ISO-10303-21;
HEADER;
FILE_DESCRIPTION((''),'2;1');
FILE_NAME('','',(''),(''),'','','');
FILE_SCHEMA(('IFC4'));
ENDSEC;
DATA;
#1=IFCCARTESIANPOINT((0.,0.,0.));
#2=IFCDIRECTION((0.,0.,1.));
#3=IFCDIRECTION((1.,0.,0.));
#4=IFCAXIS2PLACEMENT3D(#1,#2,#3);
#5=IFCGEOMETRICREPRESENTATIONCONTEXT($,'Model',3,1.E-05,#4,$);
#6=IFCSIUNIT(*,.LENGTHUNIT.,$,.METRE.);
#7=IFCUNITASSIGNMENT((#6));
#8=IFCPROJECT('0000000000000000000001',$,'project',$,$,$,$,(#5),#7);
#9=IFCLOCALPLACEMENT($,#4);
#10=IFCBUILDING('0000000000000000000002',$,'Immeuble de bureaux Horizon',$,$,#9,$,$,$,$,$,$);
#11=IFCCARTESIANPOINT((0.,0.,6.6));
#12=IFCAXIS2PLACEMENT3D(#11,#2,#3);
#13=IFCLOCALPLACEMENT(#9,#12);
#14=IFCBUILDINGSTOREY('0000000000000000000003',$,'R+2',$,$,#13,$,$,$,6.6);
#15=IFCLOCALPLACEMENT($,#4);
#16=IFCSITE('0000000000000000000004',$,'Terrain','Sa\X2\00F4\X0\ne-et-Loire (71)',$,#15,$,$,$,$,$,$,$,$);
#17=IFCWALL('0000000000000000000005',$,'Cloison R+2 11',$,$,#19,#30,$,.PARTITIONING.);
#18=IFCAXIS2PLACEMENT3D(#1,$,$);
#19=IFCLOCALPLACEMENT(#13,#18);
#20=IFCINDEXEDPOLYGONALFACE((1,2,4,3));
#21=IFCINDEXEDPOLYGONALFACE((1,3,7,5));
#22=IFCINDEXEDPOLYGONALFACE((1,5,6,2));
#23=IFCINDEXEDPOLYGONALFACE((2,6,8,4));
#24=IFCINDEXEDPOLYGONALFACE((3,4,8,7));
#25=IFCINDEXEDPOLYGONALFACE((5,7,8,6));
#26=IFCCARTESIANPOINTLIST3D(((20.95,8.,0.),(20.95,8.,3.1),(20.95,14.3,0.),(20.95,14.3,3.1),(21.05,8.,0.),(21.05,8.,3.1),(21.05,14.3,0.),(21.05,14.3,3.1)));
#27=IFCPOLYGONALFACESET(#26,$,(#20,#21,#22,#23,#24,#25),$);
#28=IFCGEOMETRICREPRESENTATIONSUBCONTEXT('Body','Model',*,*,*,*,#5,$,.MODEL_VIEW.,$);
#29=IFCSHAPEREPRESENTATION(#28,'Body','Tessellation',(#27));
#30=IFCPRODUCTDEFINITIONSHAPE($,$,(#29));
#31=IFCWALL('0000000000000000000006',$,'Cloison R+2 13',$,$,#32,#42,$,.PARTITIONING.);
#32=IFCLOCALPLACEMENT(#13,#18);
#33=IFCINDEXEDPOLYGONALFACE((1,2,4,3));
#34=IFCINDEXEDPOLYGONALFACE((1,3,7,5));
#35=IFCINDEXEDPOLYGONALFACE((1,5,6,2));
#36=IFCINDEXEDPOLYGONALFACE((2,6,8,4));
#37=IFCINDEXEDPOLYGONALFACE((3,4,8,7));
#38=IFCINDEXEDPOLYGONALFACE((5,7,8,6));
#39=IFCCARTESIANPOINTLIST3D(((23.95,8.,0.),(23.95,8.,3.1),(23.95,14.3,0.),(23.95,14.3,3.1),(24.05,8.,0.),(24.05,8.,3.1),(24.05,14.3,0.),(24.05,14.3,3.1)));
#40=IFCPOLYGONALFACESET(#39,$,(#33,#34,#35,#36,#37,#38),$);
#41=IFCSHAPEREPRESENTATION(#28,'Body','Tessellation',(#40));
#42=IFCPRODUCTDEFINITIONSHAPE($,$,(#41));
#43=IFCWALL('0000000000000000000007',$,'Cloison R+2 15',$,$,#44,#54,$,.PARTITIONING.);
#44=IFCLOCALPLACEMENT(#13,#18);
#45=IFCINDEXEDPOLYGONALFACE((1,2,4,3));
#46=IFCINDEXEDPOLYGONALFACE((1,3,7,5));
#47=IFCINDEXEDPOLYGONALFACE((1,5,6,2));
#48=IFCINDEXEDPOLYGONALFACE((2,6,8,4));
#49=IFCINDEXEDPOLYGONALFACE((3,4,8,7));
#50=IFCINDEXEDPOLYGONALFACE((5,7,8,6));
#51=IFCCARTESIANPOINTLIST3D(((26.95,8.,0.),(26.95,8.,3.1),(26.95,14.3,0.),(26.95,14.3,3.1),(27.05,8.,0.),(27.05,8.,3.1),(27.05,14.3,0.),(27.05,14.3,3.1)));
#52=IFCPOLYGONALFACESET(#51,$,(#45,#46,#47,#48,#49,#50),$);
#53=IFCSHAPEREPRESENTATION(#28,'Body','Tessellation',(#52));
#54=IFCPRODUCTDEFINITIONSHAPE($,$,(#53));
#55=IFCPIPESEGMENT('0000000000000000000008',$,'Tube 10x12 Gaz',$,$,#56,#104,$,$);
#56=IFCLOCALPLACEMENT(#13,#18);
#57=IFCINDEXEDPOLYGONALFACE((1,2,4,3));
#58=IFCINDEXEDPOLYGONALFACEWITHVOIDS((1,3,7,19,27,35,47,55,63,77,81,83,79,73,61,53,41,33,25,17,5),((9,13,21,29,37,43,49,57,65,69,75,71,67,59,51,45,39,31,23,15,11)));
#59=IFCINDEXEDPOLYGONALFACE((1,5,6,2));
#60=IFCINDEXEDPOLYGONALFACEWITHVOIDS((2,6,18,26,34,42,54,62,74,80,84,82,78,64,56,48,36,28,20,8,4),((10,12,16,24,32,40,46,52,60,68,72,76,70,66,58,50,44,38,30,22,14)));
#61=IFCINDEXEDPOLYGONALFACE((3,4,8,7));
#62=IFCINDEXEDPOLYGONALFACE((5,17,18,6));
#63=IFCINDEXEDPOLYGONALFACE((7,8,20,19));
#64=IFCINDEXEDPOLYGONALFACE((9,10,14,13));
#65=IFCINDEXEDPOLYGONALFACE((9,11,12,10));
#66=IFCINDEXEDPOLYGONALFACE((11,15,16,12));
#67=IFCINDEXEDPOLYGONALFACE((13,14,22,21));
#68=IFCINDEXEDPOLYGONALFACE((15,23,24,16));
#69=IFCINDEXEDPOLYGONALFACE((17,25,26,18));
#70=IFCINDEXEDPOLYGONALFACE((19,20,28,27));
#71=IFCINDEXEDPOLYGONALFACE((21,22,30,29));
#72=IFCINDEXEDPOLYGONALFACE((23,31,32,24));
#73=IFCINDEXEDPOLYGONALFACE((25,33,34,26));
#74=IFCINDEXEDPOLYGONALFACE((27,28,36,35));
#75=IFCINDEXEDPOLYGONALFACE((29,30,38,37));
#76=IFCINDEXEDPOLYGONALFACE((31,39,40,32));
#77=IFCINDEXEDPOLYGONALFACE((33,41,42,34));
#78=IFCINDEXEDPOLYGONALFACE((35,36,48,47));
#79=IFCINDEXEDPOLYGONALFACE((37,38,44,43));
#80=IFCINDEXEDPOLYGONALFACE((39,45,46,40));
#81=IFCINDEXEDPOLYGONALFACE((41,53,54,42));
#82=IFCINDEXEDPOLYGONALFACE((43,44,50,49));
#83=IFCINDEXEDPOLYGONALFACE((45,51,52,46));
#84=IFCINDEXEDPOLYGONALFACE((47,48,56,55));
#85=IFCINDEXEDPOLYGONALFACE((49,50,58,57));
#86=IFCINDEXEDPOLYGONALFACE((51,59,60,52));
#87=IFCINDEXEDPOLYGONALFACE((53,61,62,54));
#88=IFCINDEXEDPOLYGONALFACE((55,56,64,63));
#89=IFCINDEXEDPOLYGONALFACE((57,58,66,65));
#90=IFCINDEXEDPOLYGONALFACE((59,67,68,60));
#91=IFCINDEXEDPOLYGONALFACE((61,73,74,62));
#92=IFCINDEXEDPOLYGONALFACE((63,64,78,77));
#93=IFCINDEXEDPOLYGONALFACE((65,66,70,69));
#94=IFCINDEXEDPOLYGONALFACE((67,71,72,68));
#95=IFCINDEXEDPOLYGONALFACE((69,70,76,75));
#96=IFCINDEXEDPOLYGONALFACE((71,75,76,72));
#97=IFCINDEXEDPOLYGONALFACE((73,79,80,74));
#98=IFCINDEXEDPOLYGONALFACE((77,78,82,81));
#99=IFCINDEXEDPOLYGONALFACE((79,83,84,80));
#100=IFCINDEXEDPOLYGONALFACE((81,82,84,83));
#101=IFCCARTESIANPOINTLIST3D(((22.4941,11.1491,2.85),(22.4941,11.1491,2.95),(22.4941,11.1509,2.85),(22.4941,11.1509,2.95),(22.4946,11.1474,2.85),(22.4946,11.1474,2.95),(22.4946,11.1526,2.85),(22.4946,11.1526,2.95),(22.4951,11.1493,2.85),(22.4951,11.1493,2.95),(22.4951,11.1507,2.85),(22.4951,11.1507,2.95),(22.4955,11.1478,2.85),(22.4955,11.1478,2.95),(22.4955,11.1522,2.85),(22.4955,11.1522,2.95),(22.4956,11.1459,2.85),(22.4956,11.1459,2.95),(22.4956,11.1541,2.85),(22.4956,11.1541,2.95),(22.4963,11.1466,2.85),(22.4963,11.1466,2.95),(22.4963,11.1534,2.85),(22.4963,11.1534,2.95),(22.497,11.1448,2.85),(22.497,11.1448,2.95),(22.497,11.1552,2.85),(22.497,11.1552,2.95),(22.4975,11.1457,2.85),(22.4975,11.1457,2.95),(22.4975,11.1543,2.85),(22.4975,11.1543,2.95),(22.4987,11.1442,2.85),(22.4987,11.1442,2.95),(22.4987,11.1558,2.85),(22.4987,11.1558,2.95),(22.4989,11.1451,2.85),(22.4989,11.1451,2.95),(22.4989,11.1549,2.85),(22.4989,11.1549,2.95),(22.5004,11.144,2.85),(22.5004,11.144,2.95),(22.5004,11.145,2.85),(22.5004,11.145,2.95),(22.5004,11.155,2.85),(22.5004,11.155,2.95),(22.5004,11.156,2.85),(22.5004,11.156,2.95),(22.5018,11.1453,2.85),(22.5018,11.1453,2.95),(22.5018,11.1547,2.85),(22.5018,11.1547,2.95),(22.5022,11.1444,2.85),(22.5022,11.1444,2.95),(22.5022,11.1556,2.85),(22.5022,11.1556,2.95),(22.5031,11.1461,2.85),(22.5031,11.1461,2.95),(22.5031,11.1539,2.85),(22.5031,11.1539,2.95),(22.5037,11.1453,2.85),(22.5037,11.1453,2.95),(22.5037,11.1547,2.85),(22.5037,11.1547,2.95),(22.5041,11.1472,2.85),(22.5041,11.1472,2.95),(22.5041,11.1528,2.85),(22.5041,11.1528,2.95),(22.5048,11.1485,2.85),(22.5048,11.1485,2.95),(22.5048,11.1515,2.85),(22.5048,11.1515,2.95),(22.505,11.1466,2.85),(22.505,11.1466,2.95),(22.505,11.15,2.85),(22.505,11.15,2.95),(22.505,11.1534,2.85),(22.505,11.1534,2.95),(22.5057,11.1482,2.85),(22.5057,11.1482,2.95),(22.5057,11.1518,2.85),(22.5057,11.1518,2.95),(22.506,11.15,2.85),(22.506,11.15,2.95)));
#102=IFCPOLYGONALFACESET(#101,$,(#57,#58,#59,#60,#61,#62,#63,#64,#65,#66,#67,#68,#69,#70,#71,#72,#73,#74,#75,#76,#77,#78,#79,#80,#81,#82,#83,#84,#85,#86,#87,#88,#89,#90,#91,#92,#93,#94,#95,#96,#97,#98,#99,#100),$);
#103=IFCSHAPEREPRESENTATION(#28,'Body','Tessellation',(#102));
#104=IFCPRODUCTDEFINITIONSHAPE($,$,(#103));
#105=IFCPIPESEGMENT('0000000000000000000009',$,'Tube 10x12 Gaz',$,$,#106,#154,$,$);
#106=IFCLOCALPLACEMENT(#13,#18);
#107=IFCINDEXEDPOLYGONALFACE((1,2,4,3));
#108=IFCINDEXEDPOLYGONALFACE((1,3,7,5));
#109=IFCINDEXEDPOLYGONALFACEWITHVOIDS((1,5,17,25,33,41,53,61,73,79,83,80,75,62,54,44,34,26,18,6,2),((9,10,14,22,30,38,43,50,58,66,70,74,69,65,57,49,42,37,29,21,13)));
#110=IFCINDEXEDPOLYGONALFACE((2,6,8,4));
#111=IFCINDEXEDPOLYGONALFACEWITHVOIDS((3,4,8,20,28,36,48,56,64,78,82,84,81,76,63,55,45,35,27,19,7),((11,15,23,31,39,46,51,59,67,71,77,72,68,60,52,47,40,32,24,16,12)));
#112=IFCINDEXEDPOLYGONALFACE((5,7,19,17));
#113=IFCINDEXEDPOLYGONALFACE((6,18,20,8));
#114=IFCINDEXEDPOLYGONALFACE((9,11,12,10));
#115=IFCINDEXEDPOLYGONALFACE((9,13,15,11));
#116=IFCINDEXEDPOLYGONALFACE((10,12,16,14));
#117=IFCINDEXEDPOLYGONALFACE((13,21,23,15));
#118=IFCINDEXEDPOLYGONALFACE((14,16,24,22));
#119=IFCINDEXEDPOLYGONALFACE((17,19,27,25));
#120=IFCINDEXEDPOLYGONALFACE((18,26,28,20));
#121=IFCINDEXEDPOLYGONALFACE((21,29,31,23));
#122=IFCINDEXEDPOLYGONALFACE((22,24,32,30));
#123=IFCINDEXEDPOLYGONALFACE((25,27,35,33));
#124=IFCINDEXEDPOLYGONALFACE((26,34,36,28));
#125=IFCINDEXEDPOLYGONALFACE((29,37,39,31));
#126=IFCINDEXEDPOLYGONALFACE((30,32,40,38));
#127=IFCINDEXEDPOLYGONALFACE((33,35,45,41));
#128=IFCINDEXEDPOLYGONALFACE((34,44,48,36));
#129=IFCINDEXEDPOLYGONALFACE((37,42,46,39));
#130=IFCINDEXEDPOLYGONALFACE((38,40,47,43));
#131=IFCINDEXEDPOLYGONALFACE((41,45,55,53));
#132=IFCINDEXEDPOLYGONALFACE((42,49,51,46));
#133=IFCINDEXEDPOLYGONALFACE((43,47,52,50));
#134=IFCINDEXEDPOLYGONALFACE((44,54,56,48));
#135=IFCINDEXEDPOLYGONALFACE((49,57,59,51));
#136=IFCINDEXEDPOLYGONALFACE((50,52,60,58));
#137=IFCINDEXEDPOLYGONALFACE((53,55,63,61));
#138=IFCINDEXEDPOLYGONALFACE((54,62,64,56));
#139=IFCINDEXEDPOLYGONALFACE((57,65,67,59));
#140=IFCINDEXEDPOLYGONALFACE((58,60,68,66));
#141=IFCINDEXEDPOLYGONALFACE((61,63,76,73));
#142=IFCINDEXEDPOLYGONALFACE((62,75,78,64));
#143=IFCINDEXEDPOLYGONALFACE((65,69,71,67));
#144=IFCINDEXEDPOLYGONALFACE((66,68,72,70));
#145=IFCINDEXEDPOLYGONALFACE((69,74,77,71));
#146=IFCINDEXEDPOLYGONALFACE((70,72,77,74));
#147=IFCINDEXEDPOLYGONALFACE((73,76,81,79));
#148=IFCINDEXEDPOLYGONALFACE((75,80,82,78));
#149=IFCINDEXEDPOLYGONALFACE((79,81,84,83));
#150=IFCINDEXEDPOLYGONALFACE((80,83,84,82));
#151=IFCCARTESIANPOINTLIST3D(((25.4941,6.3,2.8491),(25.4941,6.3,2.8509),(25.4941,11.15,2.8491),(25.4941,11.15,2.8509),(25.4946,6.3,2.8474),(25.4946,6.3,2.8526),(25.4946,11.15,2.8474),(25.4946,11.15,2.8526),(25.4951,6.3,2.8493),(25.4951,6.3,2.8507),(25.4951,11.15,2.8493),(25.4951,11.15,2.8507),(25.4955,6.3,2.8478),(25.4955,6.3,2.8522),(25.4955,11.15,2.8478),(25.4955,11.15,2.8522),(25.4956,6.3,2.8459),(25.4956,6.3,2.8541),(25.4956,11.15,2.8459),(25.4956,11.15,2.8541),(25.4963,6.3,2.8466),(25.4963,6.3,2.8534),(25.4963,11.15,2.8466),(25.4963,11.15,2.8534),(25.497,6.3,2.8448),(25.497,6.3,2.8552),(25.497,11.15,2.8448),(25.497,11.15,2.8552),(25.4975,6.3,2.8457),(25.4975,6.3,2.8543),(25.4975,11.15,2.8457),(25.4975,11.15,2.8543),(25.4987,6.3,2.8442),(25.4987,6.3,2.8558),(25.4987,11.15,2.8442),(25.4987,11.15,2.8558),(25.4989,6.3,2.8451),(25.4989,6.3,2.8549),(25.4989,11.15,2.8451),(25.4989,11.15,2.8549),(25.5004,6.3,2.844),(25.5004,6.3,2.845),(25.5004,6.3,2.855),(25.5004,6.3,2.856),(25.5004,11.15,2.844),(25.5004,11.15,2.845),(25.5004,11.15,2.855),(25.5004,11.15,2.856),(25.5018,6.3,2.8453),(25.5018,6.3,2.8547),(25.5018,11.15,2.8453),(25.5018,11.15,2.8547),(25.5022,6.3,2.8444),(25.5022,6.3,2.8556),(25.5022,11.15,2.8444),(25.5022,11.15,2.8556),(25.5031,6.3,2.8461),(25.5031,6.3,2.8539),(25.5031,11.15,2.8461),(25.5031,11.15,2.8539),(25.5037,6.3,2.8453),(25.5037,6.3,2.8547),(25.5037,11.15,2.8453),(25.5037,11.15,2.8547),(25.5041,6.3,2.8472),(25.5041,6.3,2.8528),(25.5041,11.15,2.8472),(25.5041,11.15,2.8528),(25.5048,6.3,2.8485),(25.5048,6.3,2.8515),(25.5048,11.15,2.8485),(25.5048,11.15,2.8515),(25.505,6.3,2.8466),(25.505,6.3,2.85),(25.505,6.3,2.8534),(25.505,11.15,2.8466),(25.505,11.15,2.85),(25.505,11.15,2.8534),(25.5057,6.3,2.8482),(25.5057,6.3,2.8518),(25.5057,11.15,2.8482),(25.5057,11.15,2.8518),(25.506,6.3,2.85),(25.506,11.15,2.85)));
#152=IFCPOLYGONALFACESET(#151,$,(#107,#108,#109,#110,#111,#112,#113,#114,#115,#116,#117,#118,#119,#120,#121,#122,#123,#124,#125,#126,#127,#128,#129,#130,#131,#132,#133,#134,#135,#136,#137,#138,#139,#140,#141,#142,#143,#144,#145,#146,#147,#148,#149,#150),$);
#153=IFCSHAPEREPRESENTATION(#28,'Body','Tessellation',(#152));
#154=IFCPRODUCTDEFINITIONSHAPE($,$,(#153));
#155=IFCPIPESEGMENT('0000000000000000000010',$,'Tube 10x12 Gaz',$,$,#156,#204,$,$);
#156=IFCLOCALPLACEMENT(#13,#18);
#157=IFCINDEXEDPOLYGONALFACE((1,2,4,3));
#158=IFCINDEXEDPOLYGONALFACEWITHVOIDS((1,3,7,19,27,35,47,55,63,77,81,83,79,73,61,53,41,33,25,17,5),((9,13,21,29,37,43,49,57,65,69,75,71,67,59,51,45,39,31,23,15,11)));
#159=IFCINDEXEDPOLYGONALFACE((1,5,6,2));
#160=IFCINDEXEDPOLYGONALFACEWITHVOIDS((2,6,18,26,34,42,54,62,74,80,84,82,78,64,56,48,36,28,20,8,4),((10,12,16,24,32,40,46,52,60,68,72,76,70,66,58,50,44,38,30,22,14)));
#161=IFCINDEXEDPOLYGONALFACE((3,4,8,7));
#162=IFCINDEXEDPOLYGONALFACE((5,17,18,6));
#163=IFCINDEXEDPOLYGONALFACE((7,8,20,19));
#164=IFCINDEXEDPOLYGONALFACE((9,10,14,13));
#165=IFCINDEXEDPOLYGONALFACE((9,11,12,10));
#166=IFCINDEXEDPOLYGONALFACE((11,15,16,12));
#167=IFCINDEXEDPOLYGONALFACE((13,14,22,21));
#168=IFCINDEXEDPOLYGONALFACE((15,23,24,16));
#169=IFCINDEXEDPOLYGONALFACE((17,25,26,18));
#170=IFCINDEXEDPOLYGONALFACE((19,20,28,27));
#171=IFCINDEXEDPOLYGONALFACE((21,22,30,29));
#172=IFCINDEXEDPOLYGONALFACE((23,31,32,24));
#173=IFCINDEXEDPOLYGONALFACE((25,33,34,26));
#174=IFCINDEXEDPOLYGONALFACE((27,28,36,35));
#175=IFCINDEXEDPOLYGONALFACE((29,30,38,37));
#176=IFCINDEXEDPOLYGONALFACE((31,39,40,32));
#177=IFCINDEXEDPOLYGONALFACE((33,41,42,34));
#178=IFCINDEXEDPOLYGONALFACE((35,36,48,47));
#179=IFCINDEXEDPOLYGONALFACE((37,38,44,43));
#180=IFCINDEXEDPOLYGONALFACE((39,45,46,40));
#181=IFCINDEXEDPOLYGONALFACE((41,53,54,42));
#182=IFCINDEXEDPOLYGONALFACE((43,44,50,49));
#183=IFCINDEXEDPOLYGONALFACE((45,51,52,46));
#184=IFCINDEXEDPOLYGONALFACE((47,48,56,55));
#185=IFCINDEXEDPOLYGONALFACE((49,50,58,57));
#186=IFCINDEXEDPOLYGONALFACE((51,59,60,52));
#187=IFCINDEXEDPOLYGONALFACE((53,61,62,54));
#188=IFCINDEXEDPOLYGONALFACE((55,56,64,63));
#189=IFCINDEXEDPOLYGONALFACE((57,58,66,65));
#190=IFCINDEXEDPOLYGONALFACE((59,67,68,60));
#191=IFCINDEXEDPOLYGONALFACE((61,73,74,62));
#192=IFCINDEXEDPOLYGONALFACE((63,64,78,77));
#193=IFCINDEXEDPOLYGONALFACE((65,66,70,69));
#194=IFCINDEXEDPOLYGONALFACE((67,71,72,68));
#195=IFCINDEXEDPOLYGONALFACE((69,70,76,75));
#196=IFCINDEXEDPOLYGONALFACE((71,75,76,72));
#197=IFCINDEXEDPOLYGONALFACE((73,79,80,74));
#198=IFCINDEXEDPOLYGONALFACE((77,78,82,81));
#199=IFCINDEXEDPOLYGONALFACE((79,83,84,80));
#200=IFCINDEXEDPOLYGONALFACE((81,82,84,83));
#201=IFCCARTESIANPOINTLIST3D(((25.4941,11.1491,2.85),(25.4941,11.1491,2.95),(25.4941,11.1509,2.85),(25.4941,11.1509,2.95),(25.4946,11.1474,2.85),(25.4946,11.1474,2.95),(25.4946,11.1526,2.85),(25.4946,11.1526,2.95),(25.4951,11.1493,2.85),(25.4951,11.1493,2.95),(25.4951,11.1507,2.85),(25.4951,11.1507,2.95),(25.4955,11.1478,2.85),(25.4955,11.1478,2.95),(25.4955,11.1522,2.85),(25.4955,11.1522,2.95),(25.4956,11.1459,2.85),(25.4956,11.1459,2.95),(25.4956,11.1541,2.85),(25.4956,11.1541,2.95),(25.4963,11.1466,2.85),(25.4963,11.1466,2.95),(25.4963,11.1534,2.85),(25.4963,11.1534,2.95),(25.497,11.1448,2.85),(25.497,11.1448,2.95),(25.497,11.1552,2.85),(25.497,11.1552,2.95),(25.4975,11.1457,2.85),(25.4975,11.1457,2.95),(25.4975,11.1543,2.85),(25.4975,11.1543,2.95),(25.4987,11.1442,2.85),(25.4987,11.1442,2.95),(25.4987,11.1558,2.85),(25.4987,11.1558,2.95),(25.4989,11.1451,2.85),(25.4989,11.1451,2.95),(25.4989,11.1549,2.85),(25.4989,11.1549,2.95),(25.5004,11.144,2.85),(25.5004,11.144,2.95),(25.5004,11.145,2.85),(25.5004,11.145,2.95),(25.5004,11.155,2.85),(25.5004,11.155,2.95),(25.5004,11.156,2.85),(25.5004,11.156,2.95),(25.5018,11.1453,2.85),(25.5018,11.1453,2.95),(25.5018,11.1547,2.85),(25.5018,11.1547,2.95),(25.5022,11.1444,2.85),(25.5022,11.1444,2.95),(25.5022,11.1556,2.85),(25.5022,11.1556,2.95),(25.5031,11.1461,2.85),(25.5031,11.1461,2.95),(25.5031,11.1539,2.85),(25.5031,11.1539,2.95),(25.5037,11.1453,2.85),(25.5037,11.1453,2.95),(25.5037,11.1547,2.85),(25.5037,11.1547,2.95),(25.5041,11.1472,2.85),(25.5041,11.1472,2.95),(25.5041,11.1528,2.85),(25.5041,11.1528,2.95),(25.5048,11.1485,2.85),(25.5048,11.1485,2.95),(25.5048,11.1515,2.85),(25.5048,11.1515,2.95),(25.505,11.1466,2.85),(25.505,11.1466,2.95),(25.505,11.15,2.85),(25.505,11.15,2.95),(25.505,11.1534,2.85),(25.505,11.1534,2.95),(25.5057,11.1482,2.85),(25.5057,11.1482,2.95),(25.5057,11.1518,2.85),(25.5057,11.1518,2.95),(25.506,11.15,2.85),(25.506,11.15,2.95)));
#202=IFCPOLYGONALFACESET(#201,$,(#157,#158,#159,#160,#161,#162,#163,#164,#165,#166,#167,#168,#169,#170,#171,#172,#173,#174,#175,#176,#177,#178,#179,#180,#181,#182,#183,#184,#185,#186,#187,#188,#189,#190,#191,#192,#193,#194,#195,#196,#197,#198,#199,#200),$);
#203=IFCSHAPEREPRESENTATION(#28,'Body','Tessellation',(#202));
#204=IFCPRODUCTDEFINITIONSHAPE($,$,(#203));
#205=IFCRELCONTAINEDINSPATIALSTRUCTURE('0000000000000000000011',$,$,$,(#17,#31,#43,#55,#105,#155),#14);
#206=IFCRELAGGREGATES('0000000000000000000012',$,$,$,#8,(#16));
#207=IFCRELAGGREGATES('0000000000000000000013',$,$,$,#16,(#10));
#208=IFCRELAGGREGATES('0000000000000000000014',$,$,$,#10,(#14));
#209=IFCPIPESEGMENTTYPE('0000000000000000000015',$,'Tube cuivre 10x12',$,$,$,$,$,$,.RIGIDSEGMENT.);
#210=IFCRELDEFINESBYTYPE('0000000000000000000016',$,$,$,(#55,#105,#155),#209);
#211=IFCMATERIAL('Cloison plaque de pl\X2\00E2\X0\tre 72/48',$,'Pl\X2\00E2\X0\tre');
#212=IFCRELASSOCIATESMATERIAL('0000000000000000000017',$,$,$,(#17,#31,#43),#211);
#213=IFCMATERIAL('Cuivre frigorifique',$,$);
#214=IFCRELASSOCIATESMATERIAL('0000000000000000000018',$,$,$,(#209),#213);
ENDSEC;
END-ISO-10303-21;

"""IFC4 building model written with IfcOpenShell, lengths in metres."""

from ifc_helpers import new_model, si_unit, frame, frame_2d, origin_with_axes, place, context, subcontext, project, spatial, rectangle, hollow_circle, extrude, material, type_object, element, save


model = new_model("IFC4")

# Units and contexts
model_context = context("Model", 3, precision=1e-05, world=origin_with_axes())
body_context = subcontext(model_context, "Body", "Model", "MODEL_VIEW")
ifc_project = project(units=[si_unit("LENGTHUNIT", "METRE")], contexts=[model_context])

# Site, building, storey
site_placement = place(None, origin_with_axes())
site = spatial("IfcSite", under=ifc_project, at=site_placement, Name="Terrain", Description="Saône-et-Loire (71)")
building_placement = place(None, origin_with_axes())
building = spatial("IfcBuilding", under=site, at=building_placement, Name="Immeuble de bureaux Horizon")
storey_placement = place(building_placement, frame((0.0, 0.0, 6.6), z_axis=(0.0, 0.0, 1.0), x_axis=(1.0, 0.0, 0.0)))
storey = spatial("IfcBuildingStorey", under=building, at=storey_placement, Name="R+2", Elevation=6.6)

# Walls
ifc_material_1 = material(Name="Cloison plaque de plâtre 72/48", Category="Plâtre")
for number, where, z_axis, x_axis, name in (
    (1, (20.95, 8.0, 0.0), (0.0, 0.0, 1.0), (1.0, 0.0, 0.0), "Cloison R+2 11"),
    (2, (23.95, 8.0, 0.0), (0.0, 0.0, 1.0), (1.0, 0.0, 0.0), "Cloison R+2 13"),
    (3, (26.95, 8.0, 0.0), (0.0, 0.0, 1.0), (1.0, 0.0, 0.0), "Cloison R+2 15"),
):
    element("IfcWall", number, at=place(storey_placement, frame(where, z_axis=z_axis, x_axis=x_axis)), inside=storey, material=ifc_material_1, Name=name, PredefinedType="PARTITIONING", context=body_context, shape_type="SweptSolid", body=[
        extrude(rectangle(XDim=0.1, YDim=6.3, at=frame_2d((0.05, 3.15))), origin_with_axes(), (0.0, 0.0, 1.0), 3.1),
    ])

# Pipe segments
ifc_material_2 = material(Name="Cuivre frigorifique")
pipe_segment_type_1 = type_object("IfcPipeSegmentType", Name="Tube cuivre 10x12", PredefinedType="RIGIDSEGMENT", material=ifc_material_2)
pipe_segment_1_placement = place(storey_placement, frame((22.5, 11.15, 2.85), z_axis=(0.0, 0.0, 1.0), x_axis=(1.0, 0.0, 0.0)))
element("IfcPipeSegment", 4, at=pipe_segment_1_placement, inside=storey, type_object=pipe_segment_type_1, Name="Tube 10x12 Gaz", context=body_context, shape_type="SweptSolid", body=[
    extrude(hollow_circle(Radius=0.006, WallThickness=0.001), origin_with_axes(), (0.0, 0.0, 1.0), 0.1),
])
pipe_segment_2_placement = place(storey_placement, frame((25.5, 6.3, 2.85), z_axis=(0.0, 1.0, 0.0), x_axis=(1.0, 0.0, 0.0)))
element("IfcPipeSegment", 5, at=pipe_segment_2_placement, inside=storey, type_object=pipe_segment_type_1, Name="Tube 10x12 Gaz", context=body_context, shape_type="SweptSolid", body=[
    extrude(hollow_circle(Radius=0.006, WallThickness=0.001), origin_with_axes(), (0.0, 0.0, 1.0), 4.85),
])
pipe_segment_3_placement = place(storey_placement, frame((25.5, 11.15, 2.85), z_axis=(0.0, 0.0, 1.0), x_axis=(1.0, 0.0, 0.0)))
element("IfcPipeSegment", 6, at=pipe_segment_3_placement, inside=storey, type_object=pipe_segment_type_1, Name="Tube 10x12 Gaz", context=body_context, shape_type="SweptSolid", body=[
    extrude(hollow_circle(Radius=0.006, WallThickness=0.001), origin_with_axes(), (0.0, 0.0, 1.0), 0.1),
])

save(model, "model.ifc")
